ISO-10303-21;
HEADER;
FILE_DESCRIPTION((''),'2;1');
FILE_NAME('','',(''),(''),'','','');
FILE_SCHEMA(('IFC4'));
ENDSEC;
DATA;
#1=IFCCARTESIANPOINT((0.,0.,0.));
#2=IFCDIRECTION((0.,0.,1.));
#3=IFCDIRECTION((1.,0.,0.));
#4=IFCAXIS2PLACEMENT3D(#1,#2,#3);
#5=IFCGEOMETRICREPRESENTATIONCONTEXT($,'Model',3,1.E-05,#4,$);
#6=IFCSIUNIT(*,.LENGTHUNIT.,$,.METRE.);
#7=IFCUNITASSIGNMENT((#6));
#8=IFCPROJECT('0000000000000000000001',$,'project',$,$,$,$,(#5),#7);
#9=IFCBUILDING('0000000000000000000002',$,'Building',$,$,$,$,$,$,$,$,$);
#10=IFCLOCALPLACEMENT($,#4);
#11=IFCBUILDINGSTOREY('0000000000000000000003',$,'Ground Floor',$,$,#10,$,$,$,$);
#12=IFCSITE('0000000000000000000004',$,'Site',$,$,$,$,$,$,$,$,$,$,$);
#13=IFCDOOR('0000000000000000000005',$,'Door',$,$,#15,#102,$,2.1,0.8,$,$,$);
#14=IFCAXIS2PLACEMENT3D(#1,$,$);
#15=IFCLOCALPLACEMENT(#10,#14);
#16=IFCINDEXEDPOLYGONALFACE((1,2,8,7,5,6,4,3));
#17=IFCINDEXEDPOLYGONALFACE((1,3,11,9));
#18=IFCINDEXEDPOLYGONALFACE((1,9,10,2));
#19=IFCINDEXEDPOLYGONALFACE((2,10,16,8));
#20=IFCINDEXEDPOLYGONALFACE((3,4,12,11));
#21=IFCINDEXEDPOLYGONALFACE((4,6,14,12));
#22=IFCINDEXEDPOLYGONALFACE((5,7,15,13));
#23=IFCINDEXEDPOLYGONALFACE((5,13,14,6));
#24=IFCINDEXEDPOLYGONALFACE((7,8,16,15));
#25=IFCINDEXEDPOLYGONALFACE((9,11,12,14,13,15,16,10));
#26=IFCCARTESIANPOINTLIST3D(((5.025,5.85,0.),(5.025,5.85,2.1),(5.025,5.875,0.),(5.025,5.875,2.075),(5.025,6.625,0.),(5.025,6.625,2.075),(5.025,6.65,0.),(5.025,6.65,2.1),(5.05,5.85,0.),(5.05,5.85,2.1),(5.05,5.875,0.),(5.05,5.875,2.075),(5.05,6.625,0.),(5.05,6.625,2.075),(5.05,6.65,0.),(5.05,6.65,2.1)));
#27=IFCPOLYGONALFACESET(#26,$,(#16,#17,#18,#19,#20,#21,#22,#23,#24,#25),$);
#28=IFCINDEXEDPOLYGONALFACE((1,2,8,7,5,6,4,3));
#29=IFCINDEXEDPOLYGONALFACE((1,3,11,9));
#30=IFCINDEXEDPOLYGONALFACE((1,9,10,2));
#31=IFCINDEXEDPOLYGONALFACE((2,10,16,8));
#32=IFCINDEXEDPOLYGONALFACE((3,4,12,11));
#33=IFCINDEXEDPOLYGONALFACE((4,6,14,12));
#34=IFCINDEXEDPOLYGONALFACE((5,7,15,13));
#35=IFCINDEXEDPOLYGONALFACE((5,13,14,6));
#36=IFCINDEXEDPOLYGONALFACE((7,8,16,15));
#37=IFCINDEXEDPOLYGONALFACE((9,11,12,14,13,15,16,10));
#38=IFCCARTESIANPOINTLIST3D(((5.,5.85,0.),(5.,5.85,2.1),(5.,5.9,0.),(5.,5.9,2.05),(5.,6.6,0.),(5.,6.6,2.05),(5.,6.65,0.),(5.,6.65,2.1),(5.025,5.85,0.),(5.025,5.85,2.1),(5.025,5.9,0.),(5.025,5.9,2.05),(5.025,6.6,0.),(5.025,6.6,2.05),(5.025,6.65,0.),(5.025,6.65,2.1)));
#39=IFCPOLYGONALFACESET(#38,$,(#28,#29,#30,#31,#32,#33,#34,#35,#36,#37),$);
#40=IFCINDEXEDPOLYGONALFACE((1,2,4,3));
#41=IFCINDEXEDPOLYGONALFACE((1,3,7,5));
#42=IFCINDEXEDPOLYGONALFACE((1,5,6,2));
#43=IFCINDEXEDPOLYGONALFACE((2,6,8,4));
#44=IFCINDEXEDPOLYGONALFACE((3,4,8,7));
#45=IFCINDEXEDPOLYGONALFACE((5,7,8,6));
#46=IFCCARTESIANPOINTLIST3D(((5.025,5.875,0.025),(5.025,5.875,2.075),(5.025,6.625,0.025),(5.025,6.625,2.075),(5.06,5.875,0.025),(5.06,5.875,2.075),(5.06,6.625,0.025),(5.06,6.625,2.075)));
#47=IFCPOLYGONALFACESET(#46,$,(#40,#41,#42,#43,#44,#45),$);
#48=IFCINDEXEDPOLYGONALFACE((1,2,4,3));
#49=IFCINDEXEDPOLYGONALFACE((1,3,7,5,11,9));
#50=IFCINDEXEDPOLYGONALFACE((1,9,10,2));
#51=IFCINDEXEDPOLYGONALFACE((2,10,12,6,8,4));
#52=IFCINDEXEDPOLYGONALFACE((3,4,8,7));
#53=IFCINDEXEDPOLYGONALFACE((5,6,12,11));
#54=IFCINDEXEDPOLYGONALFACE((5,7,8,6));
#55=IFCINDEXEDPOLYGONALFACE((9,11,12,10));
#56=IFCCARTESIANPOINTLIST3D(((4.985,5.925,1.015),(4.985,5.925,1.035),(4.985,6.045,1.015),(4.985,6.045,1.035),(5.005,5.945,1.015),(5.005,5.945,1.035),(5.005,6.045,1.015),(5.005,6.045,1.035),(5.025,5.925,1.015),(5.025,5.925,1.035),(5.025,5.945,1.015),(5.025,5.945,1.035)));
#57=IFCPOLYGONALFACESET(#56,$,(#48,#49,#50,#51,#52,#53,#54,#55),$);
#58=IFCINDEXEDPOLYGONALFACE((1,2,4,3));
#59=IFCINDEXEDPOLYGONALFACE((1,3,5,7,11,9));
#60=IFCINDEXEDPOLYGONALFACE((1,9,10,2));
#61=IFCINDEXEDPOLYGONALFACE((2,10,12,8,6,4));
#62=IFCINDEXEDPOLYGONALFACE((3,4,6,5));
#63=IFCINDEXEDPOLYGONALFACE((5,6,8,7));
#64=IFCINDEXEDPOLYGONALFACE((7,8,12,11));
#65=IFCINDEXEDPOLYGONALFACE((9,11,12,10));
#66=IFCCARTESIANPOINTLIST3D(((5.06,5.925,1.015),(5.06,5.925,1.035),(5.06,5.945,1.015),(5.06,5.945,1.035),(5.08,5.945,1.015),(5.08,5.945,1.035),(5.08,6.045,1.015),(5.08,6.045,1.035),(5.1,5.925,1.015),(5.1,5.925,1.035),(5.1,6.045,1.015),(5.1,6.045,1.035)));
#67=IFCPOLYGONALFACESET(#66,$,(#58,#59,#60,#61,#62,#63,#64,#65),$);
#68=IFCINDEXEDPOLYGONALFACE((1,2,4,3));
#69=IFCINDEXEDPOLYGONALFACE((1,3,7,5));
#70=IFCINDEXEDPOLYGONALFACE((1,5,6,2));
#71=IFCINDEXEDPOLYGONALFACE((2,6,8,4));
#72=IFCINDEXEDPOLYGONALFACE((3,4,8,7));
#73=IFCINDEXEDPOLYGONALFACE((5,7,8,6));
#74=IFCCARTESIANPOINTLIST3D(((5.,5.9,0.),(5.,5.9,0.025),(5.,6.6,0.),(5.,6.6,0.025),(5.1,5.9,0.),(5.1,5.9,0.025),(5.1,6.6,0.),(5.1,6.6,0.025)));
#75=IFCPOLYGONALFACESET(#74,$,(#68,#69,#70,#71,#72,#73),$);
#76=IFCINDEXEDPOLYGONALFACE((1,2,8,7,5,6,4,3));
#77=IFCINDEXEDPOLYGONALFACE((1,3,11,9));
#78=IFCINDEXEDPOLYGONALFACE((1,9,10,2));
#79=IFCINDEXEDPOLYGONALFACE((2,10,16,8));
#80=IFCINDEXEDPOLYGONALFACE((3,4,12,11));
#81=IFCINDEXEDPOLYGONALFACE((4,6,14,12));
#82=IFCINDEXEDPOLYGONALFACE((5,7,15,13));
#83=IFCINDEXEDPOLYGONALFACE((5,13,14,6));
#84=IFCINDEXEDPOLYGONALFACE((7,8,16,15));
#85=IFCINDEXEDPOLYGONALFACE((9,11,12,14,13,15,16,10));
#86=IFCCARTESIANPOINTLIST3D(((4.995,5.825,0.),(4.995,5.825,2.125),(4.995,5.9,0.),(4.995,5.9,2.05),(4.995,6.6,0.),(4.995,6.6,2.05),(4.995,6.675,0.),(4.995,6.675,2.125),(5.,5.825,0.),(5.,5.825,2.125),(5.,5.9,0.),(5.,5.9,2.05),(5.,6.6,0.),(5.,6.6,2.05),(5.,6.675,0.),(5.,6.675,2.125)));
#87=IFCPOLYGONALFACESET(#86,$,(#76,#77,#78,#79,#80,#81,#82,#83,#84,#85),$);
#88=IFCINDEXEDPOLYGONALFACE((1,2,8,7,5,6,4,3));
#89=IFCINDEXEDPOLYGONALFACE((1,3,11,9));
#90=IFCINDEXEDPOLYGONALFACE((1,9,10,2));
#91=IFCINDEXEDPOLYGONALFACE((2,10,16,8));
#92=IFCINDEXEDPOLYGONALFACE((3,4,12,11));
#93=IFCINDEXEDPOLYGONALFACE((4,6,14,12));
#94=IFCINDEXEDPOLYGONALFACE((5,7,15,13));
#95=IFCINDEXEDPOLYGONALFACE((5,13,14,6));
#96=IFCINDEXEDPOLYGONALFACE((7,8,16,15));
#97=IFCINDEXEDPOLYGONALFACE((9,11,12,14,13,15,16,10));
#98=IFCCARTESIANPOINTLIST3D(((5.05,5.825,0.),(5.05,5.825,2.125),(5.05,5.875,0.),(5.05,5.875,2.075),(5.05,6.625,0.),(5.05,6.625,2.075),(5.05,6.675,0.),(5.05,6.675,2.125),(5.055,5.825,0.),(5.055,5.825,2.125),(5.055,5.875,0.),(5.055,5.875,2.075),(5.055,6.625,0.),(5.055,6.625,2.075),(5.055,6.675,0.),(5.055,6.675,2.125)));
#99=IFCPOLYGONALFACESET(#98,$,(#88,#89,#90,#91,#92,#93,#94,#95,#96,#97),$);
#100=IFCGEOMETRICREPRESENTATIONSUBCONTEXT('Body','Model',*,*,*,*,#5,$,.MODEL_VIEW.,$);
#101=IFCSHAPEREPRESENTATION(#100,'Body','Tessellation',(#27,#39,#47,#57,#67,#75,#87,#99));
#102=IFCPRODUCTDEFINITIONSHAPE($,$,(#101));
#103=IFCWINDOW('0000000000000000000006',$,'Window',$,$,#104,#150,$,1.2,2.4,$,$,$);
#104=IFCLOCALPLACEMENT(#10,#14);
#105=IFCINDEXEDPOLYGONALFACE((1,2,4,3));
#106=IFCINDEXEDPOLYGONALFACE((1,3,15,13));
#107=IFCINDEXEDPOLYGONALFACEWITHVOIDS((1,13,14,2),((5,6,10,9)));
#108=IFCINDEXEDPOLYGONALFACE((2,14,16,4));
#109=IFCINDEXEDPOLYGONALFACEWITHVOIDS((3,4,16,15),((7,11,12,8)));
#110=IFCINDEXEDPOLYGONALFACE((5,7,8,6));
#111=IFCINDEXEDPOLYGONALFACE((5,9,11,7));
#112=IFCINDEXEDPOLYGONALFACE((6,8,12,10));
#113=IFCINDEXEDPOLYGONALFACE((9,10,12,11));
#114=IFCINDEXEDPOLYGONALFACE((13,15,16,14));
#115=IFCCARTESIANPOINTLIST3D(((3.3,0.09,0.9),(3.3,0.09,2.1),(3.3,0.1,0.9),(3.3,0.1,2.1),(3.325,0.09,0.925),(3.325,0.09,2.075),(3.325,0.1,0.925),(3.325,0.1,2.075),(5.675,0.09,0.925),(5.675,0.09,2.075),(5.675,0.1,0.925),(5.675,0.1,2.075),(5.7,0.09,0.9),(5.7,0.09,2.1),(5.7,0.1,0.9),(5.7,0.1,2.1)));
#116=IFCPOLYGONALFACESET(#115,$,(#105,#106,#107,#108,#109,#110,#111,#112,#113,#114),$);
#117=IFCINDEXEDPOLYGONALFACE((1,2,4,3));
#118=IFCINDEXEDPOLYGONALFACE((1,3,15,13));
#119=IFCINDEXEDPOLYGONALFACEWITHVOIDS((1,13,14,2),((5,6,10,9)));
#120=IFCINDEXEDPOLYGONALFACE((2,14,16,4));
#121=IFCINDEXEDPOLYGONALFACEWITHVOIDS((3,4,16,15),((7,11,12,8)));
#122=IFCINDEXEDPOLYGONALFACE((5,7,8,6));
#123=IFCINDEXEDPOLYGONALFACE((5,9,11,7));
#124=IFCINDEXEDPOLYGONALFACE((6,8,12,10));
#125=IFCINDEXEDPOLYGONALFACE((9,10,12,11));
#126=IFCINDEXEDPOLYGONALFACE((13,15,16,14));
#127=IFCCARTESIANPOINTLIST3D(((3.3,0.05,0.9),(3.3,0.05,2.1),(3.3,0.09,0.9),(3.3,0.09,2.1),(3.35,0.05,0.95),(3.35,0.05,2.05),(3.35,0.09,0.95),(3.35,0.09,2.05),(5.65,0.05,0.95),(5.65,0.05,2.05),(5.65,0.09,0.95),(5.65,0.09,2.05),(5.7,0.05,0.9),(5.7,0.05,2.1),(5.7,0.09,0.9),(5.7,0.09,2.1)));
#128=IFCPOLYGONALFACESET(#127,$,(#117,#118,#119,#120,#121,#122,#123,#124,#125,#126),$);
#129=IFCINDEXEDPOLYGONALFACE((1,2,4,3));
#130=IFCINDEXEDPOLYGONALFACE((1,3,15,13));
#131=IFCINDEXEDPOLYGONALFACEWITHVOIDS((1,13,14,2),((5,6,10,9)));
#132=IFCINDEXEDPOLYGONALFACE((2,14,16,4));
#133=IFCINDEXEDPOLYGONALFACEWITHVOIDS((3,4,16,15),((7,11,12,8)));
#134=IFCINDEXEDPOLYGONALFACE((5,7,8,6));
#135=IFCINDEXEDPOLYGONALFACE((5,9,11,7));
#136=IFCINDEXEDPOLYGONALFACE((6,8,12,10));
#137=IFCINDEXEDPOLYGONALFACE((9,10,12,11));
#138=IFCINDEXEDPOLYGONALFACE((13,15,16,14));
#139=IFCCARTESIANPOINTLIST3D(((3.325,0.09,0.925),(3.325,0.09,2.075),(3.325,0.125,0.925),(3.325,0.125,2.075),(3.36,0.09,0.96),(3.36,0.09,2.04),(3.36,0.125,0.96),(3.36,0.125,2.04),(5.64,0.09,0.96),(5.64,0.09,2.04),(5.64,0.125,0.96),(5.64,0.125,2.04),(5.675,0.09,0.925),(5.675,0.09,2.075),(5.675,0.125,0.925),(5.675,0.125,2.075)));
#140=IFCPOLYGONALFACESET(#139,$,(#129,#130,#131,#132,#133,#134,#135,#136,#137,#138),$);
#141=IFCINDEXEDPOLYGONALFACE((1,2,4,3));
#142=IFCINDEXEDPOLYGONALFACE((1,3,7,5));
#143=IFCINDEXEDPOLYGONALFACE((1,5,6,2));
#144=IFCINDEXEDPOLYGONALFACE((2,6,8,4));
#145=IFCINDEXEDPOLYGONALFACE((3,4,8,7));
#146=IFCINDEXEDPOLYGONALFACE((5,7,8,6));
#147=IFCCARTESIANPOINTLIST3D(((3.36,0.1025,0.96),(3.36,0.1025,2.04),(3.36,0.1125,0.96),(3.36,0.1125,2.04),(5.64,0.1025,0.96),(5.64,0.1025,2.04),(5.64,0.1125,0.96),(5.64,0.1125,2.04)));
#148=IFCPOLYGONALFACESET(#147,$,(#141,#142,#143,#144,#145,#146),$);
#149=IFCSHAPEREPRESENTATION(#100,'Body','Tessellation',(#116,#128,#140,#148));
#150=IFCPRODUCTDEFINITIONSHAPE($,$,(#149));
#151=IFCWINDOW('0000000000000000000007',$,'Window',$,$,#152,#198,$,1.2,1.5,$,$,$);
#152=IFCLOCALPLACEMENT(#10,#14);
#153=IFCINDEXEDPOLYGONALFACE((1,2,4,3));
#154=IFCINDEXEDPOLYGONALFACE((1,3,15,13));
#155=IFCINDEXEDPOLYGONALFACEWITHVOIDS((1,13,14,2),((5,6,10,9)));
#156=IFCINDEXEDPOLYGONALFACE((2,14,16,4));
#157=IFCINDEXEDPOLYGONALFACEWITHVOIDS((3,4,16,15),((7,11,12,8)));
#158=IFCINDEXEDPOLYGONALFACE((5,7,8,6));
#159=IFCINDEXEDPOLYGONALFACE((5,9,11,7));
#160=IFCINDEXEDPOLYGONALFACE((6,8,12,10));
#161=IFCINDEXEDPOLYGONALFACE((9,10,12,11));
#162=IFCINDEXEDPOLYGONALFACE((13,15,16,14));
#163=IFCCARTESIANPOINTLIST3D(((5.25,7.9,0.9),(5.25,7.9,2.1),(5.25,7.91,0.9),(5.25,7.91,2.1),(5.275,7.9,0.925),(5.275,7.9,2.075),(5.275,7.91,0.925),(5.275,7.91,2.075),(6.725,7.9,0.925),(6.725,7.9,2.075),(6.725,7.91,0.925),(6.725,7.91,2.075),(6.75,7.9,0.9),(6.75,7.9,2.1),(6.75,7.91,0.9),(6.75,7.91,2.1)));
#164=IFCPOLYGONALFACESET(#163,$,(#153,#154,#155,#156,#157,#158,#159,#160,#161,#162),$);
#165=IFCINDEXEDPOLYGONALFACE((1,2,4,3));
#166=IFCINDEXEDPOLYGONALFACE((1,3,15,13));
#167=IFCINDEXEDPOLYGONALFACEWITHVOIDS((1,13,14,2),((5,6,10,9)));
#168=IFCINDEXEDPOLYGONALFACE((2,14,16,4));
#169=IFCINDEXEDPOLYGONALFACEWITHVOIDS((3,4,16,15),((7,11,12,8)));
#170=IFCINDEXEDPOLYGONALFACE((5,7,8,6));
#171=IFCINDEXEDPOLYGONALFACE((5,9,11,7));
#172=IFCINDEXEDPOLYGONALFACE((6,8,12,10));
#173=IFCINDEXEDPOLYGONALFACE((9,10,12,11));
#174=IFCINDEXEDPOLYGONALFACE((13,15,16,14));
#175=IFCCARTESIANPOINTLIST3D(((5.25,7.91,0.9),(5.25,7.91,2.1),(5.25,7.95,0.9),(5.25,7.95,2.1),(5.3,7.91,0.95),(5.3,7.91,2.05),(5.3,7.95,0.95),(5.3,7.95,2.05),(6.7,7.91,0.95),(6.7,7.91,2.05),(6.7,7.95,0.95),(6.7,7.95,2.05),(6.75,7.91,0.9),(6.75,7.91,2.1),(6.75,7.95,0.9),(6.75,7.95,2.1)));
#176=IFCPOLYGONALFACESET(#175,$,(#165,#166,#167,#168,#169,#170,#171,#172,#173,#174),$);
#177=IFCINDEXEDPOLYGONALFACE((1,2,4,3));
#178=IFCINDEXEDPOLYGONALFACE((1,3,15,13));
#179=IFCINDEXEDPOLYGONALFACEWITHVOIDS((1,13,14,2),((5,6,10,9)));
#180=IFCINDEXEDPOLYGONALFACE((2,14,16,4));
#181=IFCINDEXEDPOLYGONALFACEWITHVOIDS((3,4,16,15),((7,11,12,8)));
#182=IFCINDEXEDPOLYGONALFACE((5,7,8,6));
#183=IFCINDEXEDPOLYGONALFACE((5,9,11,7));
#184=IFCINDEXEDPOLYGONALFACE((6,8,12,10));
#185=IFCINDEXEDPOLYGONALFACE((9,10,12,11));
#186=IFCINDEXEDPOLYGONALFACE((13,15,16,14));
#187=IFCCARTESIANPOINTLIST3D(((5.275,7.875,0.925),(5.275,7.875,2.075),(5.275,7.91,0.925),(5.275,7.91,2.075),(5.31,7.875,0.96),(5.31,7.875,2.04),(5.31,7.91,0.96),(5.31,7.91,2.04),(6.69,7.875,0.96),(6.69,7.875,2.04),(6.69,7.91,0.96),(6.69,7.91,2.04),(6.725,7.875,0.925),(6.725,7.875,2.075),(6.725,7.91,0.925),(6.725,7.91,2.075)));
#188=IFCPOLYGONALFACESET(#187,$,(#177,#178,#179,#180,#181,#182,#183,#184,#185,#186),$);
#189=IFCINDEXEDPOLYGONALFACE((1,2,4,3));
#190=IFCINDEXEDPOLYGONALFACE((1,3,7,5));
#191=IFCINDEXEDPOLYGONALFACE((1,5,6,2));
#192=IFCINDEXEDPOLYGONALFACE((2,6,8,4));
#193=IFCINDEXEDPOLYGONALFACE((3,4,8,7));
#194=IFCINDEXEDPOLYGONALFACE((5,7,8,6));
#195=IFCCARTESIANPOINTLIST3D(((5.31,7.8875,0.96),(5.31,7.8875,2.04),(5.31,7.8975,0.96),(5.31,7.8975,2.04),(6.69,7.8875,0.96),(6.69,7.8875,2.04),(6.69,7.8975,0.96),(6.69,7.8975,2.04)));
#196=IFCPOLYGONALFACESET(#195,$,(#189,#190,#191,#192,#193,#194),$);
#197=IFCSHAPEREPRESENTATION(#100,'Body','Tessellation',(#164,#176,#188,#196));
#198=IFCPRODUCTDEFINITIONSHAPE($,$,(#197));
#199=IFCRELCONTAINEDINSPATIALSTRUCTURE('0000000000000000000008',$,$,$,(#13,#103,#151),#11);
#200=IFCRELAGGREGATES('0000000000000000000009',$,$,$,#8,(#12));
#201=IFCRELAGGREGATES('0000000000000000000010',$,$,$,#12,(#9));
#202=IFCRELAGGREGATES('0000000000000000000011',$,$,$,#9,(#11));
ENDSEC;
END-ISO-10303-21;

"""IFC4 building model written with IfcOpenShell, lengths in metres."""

from ifc_helpers import new_model, si_unit, frame, origin_with_axes, place, context, subcontext, project, spatial, line, indexed_curve, outline, extrude, element, save


model = new_model("IFC4")

# Units and contexts
model_context = context("Model", 3, precision=1e-05, world=origin_with_axes())
body_context = subcontext(model_context, "Body", "Model", "MODEL_VIEW")
ifc_project = project(units=[si_unit("LENGTHUNIT", "METRE")], contexts=[model_context])

# Site, building, storey
site = spatial("IfcSite", under=ifc_project, Name="Site")
building = spatial("IfcBuilding", under=site, Name="Building")
storey_placement = place(None, origin_with_axes())
storey = spatial("IfcBuildingStorey", under=building, at=storey_placement, Name="Ground Floor")

# Door
door_1_placement = place(storey_placement, frame((5.0, 6.65, 0.0), z_axis=(0.0, 0.0, 1.0), x_axis=(0.0, -1.0, 0.0)))
element("IfcDoor", 1, at=door_1_placement, inside=storey, Name="Door", OverallHeight=2.1, OverallWidth=0.8, context=body_context, shape_type="SweptSolid", body=[
    extrude(outline(indexed_curve([(0.0, 0.0), (0.0, 2.1), (0.8, 2.1), (0.8, 0.0), (0.775, 0.0), (0.775, 2.075), (0.025, 2.075), (0.025, 0.0)], segments=[line(1, 2, 3, 4, 5, 6, 7, 8, 1)])), frame((0.0, 0.025, 0.0), z_axis=(0.0, -1.0, 0.0), x_axis=(1.0, 0.0, 0.0)), (0.0, 0.0, -1.0), 0.025),
    extrude(outline(indexed_curve([(0.0, 0.0), (0.0, 2.1), (0.8, 2.1), (0.8, 0.0), (0.75, 0.0), (0.75, 2.05), (0.05, 2.05), (0.05, 0.0)], segments=[line(1, 2, 3, 4, 5, 6, 7, 8, 1)])), frame((0.0, 0.0, 0.0), z_axis=(0.0, -1.0, 0.0), x_axis=(1.0, 0.0, 0.0)), (0.0, 0.0, -1.0), 0.025),
    extrude(outline(indexed_curve([(0.0, 0.0), (0.75, 0.0), (0.75, 0.035), (0.0, 0.035)], segments=[line(1, 2, 3, 4, 1)])), frame((0.025, 0.025, 0.025), z_axis=(0.0, 0.0, 1.0), x_axis=(1.0, 0.0, 0.0)), (0.0, 0.0, 1.0), 2.05),
    extrude(outline(indexed_curve([(0.0, 0.0), (0.0, -0.04), (-0.12, -0.04), (-0.12, -0.02), (-0.02, -0.02), (-0.02, 0.0)], segments=[line(1, 2, 3, 4, 5, 6, 1)])), frame((0.725, 0.025, 1.015), z_axis=(0.0, 0.0, 1.0), x_axis=(1.0, 0.0, 0.0)), (0.0, 0.0, 1.0), 0.02),
    extrude(outline(indexed_curve([(0.0, 0.0), (0.0, 0.04), (-0.12, 0.04), (-0.12, 0.02), (-0.02, 0.02), (-0.02, 0.0)], segments=[line(1, 2, 3, 4, 5, 6, 1)])), frame((0.725, 0.06, 1.015), z_axis=(0.0, 0.0, 1.0), x_axis=(1.0, 0.0, 0.0)), (0.0, 0.0, 1.0), 0.02),
    extrude(outline(indexed_curve([(0.0, 0.0), (0.7, 0.0), (0.7, 0.1), (0.0, 0.1)], segments=[line(1, 2, 3, 4, 1)])), frame((0.05, 0.0, 0.0), z_axis=(0.0, 0.0, 1.0), x_axis=(1.0, 0.0, 0.0)), (0.0, 0.0, 1.0), 0.025),
    extrude(outline(indexed_curve([(0.0, 0.0), (0.0, 2.125), (0.85, 2.125), (0.85, 0.0), (0.775, 0.0), (0.775, 2.05), (0.075, 2.05), (0.075, 0.0)], segments=[line(1, 2, 3, 4, 5, 6, 7, 8, 1)])), frame((-0.025, -0.005, 0.0), z_axis=(0.0, -1.0, 0.0), x_axis=(1.0, 0.0, 0.0)), (0.0, 0.0, -1.0), 0.005),
    extrude(outline(indexed_curve([(0.0, 0.0), (0.0, 2.125), (0.85, 2.125), (0.85, 0.0), (0.8, 0.0), (0.8, 2.075), (0.05, 2.075), (0.05, 0.0)], segments=[line(1, 2, 3, 4, 5, 6, 7, 8, 1)])), frame((-0.025, 0.05, 0.0), z_axis=(0.0, -1.0, 0.0), x_axis=(1.0, 0.0, 0.0)), (0.0, 0.0, -1.0), 0.005),
])

# Windows
window_1_placement = place(storey_placement, frame((3.3, 0.0, 0.9), z_axis=(0.0, 0.0, 1.0), x_axis=(1.0, 0.0, 0.0)))
element("IfcWindow", 2, at=window_1_placement, inside=storey, Name="Window", OverallHeight=1.2, OverallWidth=2.4, context=body_context, shape_type="SweptSolid", body=[
    extrude(outline(indexed_curve([(0.0, 0.0), (2.4, 0.0), (2.4, 1.2), (0.0, 1.2)], segments=[line(1, 2, 3, 4, 1)]), holes=[indexed_curve([(0.025, 0.025), (2.375, 0.025), (2.375, 1.175), (0.025, 1.175)], segments=[line(1, 2, 3, 4, 1)])]), frame((0.0, 0.09, 0.0), z_axis=(0.0, -1.0, 0.0), x_axis=(1.0, 0.0, 0.0)), (0.0, 0.0, -1.0), 0.01),
    extrude(outline(indexed_curve([(0.0, 0.0), (2.4, 0.0), (2.4, 1.2), (0.0, 1.2)], segments=[line(1, 2, 3, 4, 1)]), holes=[indexed_curve([(0.05, 0.05), (2.35, 0.05), (2.35, 1.15), (0.05, 1.15)], segments=[line(1, 2, 3, 4, 1)])]), frame((0.0, 0.05, 0.0), z_axis=(0.0, -1.0, 0.0), x_axis=(1.0, 0.0, 0.0)), (0.0, 0.0, -1.0), 0.04),
    extrude(outline(indexed_curve([(0.0, 0.0), (2.35, 0.0), (2.35, 1.15), (0.0, 1.15)], segments=[line(1, 2, 3, 4, 1)]), holes=[indexed_curve([(0.035, 0.035), (2.315, 0.035), (2.315, 1.115), (0.035, 1.115)], segments=[line(1, 2, 3, 4, 1)])]), frame((0.025, 0.09, 0.025), z_axis=(0.0, -1.0, 0.0), x_axis=(1.0, 0.0, 0.0)), (0.0, 0.0, -1.0), 0.035),
    extrude(outline(indexed_curve([(0.035, 0.035), (2.315, 0.035), (2.315, 1.115), (0.035, 1.115)], segments=[line(1, 2, 3, 4, 1)])), frame((0.025, 0.1025, 0.025), z_axis=(0.0, -1.0, 0.0), x_axis=(1.0, 0.0, 0.0)), (0.0, 0.0, -1.0), 0.01),
])
window_2_placement = place(storey_placement, frame((6.75, 8.0, 0.9), z_axis=(0.0, 0.0, 1.0), x_axis=(-1.0, 0.0, 0.0)))
element("IfcWindow", 3, at=window_2_placement, inside=storey, Name="Window", OverallHeight=1.2, OverallWidth=1.5, context=body_context, shape_type="SweptSolid", body=[
    extrude(outline(indexed_curve([(0.0, 0.0), (1.5, 0.0), (1.5, 1.2), (0.0, 1.2)], segments=[line(1, 2, 3, 4, 1)]), holes=[indexed_curve([(0.025, 0.025), (1.475, 0.025), (1.475, 1.175), (0.025, 1.175)], segments=[line(1, 2, 3, 4, 1)])]), frame((0.0, 0.09, 0.0), z_axis=(0.0, -1.0, 0.0), x_axis=(1.0, 0.0, 0.0)), (0.0, 0.0, -1.0), 0.01),
    extrude(outline(indexed_curve([(0.0, 0.0), (1.5, 0.0), (1.5, 1.2), (0.0, 1.2)], segments=[line(1, 2, 3, 4, 1)]), holes=[indexed_curve([(0.05, 0.05), (1.45, 0.05), (1.45, 1.15), (0.05, 1.15)], segments=[line(1, 2, 3, 4, 1)])]), frame((0.0, 0.05, 0.0), z_axis=(0.0, -1.0, 0.0), x_axis=(1.0, 0.0, 0.0)), (0.0, 0.0, -1.0), 0.04),
    extrude(outline(indexed_curve([(0.0, 0.0), (1.45, 0.0), (1.45, 1.15), (0.0, 1.15)], segments=[line(1, 2, 3, 4, 1)]), holes=[indexed_curve([(0.035, 0.035), (1.415, 0.035), (1.415, 1.115), (0.035, 1.115)], segments=[line(1, 2, 3, 4, 1)])]), frame((0.025, 0.09, 0.025), z_axis=(0.0, -1.0, 0.0), x_axis=(1.0, 0.0, 0.0)), (0.0, 0.0, -1.0), 0.035),
    extrude(outline(indexed_curve([(0.035, 0.035), (1.415, 0.035), (1.415, 1.115), (0.035, 1.115)], segments=[line(1, 2, 3, 4, 1)])), frame((0.025, 0.1025, 0.025), z_axis=(0.0, -1.0, 0.0), x_axis=(1.0, 0.0, 0.0)), (0.0, 0.0, -1.0), 0.01),
])

save(model, "model.ifc")
